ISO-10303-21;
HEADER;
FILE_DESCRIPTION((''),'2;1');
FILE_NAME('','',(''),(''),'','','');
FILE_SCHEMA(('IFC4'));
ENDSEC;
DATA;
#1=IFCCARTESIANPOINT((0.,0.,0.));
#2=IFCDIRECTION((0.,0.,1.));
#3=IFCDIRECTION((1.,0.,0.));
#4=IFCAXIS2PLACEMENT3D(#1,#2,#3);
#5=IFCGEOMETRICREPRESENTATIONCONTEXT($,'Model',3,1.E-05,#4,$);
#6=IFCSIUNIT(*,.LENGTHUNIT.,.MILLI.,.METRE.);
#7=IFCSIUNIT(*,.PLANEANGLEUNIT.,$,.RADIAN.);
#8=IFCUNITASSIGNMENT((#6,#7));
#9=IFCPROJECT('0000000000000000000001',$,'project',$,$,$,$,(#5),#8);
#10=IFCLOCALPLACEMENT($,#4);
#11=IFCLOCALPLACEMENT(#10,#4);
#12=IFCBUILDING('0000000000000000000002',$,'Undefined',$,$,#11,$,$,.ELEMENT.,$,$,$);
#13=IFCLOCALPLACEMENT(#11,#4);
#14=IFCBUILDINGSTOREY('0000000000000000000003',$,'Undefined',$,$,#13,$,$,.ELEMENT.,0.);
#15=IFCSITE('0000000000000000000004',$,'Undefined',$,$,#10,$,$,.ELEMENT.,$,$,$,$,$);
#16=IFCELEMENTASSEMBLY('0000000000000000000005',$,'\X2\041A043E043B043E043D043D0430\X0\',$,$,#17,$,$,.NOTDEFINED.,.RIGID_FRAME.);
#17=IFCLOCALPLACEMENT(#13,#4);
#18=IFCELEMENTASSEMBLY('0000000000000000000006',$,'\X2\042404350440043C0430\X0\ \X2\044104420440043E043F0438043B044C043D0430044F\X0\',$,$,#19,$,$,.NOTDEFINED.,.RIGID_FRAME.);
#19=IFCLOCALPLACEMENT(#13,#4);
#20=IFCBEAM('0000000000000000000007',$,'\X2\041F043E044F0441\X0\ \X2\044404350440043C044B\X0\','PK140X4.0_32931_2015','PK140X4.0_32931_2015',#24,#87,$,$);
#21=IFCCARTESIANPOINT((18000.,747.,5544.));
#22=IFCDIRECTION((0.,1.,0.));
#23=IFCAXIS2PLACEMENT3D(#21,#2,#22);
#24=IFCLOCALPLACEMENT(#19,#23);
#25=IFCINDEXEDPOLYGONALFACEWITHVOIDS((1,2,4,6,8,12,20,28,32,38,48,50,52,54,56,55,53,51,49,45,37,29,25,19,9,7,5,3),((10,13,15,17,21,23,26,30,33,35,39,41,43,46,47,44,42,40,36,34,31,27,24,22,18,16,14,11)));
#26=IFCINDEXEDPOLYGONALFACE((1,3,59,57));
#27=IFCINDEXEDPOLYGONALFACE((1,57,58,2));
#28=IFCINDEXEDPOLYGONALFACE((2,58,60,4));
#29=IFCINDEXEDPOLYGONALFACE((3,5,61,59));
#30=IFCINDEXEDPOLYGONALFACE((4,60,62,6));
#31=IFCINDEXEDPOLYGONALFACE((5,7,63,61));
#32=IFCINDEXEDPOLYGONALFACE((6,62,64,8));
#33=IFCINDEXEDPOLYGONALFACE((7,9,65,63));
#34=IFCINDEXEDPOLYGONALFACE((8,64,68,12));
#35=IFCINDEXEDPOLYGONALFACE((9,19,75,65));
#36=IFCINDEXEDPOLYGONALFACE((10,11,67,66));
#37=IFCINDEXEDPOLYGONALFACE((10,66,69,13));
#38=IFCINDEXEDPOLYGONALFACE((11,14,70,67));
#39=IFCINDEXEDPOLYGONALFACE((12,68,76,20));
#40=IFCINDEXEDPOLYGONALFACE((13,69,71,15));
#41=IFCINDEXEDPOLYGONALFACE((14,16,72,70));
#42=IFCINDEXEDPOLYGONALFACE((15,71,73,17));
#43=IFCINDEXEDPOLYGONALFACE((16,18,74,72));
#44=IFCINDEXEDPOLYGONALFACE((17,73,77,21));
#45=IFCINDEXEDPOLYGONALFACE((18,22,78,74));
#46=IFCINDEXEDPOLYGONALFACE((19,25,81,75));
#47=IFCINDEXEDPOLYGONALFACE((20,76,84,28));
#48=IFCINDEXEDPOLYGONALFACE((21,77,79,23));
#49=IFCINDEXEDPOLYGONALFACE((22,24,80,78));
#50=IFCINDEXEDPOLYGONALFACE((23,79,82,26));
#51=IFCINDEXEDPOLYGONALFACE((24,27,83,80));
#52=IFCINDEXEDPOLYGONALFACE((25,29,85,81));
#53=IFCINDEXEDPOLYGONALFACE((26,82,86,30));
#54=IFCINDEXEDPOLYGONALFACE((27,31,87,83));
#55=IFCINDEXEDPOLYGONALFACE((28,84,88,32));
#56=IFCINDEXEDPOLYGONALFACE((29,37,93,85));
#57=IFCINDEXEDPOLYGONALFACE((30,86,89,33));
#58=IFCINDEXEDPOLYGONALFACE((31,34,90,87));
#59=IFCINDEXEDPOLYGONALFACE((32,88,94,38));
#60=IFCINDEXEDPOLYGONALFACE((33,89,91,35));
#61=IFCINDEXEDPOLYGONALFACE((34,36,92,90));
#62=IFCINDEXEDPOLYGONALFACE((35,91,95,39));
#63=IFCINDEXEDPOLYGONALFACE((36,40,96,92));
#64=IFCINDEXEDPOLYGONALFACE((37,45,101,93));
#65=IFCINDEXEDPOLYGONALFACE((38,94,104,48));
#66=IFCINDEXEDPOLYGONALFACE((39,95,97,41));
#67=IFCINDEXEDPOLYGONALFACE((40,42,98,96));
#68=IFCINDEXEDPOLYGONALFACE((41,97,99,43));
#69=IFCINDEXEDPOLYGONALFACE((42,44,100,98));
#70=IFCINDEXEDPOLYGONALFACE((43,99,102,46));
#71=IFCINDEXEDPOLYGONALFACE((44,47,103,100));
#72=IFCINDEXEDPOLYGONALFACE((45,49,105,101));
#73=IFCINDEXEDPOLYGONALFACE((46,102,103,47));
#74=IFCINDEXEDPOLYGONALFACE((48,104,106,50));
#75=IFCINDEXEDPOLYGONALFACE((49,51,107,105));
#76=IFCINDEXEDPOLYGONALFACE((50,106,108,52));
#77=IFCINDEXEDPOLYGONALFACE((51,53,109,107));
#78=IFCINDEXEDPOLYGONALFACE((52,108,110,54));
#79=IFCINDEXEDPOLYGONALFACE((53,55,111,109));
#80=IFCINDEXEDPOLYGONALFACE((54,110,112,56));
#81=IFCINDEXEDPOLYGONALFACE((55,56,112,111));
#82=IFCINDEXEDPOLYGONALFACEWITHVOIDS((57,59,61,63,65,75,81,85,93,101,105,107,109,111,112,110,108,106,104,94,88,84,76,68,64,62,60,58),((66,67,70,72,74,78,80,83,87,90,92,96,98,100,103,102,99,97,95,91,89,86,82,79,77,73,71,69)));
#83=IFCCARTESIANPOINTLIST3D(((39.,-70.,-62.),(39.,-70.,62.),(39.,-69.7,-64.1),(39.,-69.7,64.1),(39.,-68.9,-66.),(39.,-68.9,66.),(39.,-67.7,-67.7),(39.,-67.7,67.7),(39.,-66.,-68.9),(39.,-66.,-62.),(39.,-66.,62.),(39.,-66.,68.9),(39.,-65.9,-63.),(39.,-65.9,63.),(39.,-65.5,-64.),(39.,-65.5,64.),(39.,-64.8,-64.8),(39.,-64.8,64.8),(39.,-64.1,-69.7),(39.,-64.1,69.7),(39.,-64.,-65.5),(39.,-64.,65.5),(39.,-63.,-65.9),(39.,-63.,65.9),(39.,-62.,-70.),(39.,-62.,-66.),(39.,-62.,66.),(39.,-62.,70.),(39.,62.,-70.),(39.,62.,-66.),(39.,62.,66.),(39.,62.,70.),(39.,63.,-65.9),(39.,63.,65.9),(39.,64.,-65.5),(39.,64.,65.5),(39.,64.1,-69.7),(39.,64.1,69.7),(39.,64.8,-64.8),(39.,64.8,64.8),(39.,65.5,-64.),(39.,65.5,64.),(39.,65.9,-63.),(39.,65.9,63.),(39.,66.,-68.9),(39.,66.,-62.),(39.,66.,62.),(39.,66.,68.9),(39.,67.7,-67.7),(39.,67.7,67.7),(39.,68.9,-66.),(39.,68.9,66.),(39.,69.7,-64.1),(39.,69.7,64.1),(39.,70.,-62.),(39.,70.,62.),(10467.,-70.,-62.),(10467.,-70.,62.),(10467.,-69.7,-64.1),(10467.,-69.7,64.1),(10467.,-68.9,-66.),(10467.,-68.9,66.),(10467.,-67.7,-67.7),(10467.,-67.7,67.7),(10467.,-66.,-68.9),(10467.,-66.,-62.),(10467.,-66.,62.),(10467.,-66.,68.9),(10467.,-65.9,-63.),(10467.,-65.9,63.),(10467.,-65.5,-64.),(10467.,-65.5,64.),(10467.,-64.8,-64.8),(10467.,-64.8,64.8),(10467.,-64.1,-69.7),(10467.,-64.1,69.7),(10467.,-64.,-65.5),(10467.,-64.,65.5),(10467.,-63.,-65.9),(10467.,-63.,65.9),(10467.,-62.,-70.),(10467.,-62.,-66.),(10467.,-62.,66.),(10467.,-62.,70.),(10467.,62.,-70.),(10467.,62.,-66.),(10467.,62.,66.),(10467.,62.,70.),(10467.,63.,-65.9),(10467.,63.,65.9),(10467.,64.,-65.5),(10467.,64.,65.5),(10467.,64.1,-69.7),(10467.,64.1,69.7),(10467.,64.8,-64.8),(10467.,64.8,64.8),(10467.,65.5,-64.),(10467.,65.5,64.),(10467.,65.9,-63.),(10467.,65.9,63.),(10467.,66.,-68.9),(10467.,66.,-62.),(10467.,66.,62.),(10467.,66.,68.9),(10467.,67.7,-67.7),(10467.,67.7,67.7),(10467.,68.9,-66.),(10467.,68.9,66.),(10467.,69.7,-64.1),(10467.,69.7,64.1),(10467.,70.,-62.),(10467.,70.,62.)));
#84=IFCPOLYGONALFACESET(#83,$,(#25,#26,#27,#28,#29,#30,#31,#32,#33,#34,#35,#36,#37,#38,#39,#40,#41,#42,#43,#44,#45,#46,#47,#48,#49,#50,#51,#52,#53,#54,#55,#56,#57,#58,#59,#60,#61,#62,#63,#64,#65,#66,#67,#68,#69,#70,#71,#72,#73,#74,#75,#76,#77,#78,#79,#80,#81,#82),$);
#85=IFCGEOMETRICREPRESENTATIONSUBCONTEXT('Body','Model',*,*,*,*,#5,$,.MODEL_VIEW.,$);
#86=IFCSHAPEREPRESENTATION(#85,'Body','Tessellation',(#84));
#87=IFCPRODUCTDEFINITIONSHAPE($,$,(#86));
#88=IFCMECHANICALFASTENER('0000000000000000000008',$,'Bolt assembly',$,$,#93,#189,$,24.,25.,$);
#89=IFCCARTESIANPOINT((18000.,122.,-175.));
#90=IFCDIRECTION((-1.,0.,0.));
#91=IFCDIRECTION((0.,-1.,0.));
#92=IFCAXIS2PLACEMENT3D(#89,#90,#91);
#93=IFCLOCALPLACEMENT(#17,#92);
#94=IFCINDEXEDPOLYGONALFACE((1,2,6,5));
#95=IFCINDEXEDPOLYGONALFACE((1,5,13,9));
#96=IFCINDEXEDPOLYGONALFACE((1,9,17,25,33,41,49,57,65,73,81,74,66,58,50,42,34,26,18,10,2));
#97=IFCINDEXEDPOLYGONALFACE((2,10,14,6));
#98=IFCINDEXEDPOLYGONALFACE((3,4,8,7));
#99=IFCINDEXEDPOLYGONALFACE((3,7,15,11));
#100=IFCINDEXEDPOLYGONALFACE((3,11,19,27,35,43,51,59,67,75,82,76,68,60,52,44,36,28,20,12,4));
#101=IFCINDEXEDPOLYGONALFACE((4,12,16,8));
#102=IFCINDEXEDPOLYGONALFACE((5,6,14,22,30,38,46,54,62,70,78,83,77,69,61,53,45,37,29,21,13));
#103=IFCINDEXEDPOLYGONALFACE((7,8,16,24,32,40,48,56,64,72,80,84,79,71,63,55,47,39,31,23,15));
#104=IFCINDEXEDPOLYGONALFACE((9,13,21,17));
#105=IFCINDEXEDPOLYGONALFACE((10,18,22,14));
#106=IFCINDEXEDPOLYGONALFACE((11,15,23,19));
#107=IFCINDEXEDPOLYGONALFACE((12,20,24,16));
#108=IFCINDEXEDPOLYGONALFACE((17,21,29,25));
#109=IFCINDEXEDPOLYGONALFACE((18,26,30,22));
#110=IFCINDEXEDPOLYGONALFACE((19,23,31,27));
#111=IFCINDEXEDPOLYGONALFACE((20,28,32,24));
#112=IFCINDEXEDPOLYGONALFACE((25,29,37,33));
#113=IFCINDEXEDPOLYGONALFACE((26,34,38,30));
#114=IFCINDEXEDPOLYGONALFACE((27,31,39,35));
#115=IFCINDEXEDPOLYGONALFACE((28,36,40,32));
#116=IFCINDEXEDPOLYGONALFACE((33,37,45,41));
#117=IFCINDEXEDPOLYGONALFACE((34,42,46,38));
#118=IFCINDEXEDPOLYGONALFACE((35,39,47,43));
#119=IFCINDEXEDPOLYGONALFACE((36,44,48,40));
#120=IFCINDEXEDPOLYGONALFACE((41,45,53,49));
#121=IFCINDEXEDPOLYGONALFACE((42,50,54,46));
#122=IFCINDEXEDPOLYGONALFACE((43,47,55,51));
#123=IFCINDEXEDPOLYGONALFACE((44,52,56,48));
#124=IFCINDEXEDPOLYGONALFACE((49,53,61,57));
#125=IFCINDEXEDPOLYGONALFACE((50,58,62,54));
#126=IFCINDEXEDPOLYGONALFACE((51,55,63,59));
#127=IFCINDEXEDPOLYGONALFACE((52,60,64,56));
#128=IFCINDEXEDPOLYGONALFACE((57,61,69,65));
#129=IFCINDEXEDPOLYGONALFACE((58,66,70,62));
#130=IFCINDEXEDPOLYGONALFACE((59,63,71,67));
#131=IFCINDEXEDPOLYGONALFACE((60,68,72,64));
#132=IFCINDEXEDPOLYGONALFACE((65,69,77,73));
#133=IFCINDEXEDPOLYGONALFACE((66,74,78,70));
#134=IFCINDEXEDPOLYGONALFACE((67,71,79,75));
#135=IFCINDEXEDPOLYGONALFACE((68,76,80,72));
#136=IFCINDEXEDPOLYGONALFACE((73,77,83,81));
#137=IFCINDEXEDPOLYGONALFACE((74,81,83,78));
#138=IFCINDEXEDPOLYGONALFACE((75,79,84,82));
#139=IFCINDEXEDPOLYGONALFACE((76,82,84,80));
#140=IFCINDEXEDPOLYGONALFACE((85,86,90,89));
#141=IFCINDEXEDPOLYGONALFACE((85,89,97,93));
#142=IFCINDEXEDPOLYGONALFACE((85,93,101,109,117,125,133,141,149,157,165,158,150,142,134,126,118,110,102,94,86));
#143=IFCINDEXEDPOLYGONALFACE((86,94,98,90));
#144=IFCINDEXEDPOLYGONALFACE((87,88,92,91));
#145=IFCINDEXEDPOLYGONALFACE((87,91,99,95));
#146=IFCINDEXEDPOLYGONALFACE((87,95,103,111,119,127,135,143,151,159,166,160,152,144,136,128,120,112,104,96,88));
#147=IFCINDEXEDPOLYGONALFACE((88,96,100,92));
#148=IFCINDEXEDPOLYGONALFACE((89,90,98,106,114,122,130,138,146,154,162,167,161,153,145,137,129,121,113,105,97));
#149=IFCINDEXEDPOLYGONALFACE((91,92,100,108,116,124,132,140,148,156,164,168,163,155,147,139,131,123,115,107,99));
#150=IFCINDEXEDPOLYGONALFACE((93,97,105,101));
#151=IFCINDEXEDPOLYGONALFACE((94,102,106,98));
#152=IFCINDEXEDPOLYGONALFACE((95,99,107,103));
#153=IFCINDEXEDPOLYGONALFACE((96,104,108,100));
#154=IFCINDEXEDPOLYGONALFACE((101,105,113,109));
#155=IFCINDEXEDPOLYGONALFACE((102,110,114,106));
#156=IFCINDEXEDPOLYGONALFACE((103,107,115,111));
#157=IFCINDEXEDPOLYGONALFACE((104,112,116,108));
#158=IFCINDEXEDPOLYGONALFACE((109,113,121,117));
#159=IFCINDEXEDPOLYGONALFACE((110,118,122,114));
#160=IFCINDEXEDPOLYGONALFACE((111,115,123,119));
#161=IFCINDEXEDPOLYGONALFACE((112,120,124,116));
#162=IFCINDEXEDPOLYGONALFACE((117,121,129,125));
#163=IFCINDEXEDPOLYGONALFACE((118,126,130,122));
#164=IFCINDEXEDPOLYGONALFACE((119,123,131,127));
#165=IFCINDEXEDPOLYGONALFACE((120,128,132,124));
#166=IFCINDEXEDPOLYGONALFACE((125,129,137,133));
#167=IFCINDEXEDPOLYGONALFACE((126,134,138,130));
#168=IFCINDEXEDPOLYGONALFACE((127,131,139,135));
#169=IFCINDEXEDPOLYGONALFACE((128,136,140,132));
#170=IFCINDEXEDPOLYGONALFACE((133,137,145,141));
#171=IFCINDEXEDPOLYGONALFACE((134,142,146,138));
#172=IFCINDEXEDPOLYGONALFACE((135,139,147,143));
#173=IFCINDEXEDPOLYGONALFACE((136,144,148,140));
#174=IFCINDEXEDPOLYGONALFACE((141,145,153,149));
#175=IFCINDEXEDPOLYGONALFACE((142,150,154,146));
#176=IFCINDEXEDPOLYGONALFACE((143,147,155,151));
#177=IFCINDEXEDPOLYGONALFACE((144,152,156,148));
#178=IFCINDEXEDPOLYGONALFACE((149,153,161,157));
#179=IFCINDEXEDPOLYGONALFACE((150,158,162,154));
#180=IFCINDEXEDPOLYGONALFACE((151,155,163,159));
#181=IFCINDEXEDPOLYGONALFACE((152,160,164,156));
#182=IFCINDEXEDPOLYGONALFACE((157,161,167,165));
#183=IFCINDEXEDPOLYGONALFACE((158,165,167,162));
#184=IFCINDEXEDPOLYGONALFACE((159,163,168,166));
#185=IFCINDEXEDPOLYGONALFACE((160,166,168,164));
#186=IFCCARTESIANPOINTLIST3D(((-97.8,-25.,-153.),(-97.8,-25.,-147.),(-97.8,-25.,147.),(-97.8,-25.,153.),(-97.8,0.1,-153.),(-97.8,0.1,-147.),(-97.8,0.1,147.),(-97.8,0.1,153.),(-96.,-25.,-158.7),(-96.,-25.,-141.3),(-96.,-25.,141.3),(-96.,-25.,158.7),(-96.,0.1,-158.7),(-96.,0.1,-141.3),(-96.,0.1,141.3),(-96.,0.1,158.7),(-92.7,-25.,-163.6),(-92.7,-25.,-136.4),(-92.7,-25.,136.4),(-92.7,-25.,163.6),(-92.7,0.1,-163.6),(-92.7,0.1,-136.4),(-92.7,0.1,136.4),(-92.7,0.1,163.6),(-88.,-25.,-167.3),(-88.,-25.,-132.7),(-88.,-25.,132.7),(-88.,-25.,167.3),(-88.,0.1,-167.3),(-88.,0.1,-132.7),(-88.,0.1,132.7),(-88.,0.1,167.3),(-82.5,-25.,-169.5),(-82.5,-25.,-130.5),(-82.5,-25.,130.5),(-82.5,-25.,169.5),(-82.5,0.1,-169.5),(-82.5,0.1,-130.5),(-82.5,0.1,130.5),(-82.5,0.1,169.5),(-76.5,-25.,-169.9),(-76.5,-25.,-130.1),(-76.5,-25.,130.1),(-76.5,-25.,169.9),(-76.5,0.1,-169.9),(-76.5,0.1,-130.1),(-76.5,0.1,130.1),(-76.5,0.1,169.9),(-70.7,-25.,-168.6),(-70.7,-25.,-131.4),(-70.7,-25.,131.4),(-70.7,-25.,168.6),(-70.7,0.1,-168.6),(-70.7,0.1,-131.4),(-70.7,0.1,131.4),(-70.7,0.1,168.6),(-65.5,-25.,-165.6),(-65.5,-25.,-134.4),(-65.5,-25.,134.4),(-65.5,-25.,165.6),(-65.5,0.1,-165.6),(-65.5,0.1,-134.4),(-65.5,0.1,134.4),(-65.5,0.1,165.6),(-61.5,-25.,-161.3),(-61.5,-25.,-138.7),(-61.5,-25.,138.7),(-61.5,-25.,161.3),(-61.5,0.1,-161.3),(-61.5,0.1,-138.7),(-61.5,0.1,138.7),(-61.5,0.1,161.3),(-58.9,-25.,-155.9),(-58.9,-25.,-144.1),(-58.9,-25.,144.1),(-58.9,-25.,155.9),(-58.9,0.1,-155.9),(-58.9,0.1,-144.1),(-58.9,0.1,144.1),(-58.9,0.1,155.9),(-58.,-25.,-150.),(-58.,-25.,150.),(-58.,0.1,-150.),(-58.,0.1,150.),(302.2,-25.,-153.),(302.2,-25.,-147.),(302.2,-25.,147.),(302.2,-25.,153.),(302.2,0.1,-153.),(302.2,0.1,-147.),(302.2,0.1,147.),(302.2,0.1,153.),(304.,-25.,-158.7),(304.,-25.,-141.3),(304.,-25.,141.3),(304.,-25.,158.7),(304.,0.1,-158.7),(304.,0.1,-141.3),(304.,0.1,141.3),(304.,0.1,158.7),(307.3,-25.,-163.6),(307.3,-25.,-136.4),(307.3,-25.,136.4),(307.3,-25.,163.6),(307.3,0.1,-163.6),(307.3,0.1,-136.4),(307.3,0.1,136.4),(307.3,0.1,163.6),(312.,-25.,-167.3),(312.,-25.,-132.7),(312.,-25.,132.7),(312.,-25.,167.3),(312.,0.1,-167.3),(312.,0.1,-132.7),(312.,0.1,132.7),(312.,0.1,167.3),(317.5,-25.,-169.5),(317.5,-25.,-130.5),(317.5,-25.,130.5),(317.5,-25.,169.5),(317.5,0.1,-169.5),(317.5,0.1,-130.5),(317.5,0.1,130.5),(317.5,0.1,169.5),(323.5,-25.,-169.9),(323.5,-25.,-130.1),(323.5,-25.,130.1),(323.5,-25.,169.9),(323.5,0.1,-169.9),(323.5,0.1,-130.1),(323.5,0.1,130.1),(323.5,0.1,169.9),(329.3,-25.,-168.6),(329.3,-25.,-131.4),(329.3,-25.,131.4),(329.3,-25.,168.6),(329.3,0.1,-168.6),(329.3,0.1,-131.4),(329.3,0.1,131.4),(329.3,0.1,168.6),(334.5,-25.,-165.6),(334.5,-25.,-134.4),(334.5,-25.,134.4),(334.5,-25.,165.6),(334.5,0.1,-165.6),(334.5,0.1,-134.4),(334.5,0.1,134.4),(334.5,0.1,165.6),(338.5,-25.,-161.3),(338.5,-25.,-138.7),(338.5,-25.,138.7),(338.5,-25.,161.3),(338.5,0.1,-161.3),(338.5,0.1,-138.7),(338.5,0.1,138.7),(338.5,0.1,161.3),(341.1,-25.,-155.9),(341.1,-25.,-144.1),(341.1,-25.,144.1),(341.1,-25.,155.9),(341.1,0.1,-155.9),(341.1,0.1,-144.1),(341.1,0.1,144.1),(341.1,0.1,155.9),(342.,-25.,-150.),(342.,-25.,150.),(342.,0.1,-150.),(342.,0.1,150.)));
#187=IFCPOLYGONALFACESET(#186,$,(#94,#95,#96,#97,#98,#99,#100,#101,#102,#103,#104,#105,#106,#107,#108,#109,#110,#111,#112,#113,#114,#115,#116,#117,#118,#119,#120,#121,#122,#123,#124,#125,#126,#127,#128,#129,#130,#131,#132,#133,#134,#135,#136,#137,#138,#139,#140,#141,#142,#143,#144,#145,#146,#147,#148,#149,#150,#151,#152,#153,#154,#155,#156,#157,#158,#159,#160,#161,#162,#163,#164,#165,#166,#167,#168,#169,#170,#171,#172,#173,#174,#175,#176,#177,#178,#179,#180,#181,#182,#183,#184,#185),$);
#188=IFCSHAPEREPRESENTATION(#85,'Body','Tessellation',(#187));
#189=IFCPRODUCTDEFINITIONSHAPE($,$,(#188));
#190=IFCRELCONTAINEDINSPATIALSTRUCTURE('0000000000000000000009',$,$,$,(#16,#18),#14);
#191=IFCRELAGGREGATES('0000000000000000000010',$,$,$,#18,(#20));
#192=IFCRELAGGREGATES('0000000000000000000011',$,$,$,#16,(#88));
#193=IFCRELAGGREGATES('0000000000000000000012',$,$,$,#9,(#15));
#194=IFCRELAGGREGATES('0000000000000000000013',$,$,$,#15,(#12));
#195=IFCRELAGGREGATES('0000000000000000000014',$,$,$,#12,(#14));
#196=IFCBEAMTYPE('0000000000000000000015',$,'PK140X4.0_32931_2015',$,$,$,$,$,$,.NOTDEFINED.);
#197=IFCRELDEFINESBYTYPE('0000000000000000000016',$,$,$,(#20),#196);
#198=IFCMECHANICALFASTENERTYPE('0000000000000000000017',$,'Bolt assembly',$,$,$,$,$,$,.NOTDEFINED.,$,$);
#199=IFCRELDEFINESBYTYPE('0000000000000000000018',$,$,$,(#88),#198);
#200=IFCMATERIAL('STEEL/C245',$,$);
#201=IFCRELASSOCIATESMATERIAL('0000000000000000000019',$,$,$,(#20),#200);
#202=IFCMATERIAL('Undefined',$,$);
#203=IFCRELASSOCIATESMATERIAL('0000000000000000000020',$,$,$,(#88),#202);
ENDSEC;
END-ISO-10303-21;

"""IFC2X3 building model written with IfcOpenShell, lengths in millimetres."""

from ifc_helpers import new_model, si_unit, frame, origin_with_axes, origin_2d_with_axis, place, context, subcontext, project, spatial, hollow_rectangle, circle, extrude, clip, halfspace, source, transform, mapped, material, type_object, element, aggregate, save


model = new_model("IFC2X3")

# Units and contexts
model_context = context("Model", 3, precision=1e-05, world=origin_with_axes())
body_context = subcontext(model_context, "Body", "Model", "MODEL_VIEW")
ifc_project = project(units=[si_unit("LENGTHUNIT", "METRE", prefix="MILLI"), si_unit("PLANEANGLEUNIT", "RADIAN")], contexts=[model_context])

# Site, building, storey
site_placement = place(None, origin_with_axes())
site = spatial("IfcSite", under=ifc_project, at=site_placement, Name="Undefined", CompositionType="ELEMENT")
building_placement = place(site_placement, origin_with_axes())
building = spatial("IfcBuilding", under=site, at=building_placement, Name="Undefined", CompositionType="ELEMENT")
storey_placement = place(building_placement, origin_with_axes())
storey = spatial("IfcBuildingStorey", under=building, at=storey_placement, Name="Undefined", CompositionType="ELEMENT", Elevation=0.0)

# Element assembly
ifc_material_1 = material(Name="STEEL/C245")
assembly_1_placement = place(storey_placement, origin_with_axes())
assembly_1 = element("IfcElementAssembly", 1, at=assembly_1_placement, inside=storey, Name="Колонна", AssemblyPlace="NOTDEFINED", PredefinedType="RIGID_FRAME")

# Element assembly, beam
assembly_2_placement = place(storey_placement, origin_with_axes())
assembly_2 = element("IfcElementAssembly", 2, at=assembly_2_placement, inside=storey, Name="Ферма стропильная", AssemblyPlace="NOTDEFINED", PredefinedType="RIGID_FRAME")
beam_type_1 = type_object("IfcBeamType", Name="PK140X4.0_32931_2015", PredefinedType="NOTDEFINED")
beam_1_placement = place(assembly_2_placement, frame((18000.0, 747.0, 5544.0), z_axis=(0.0, 0.0, 1.0), x_axis=(0.0, 1.0, 0.0)))
beam_1 = element("IfcBeam", 3, at=beam_1_placement, type_object=beam_type_1, material=ifc_material_1, Name="Пояс фермы", Description="PK140X4.0_32931_2015", ObjectType="PK140X4.0_32931_2015", context=body_context, shape_type="Clipping", body=[
    clip(clip(extrude(hollow_rectangle(XDim=140.0, YDim=140.0, WallThickness=4.0, InnerFilletRadius=4.0, OuterFilletRadius=8.0, at=origin_2d_with_axis()), frame((10467.0, 0.0, 0.0), z_axis=(-1.0, 0.0, 0.0), x_axis=(0.0, -1.0, 0.0)), (0.0, 0.0, 1.0), 10428.0), halfspace(frame((10467.0, 0.0, -70.0), z_axis=(-1.0, 0.0, 0.0), x_axis=(0.0, 1.0, 0.0)), True)), halfspace(frame((39.0, 0.0, -70.0), z_axis=(1.0, 0.0, 0.0), x_axis=(0.0, -1.0, 0.0)), True)),
])

aggregate(assembly_2, [beam_1])

# Mechanical fastener
ifc_material_2 = material(Name="Undefined")
mechanical_fastener_type = type_object("IfcMechanicalFastenerType", Name="Bolt assembly")
shared_shape_1 = source(origin_with_axes(), body_context, "Body", "SweptSolid", [
    extrude(circle(Radius=20.0, at=origin_2d_with_axis()), frame((0.0, -25.0, 0.0), z_axis=(0.0, 1.0, 0.0), x_axis=(1.0, 0.0, 0.0)), (0.0, 0.0, 1.0), 25.1),
])
mechanical_fastener_1_placement = place(assembly_1_placement, frame((18000.0, 122.0, -175.0), z_axis=(-1.0, 0.0, 0.0), x_axis=(0.0, -1.0, 0.0)))
mechanical_fastener_1 = element("IfcMechanicalFastener", 4, at=mechanical_fastener_1_placement, type_object=mechanical_fastener_type, material=ifc_material_2, Name="Bolt assembly", NominalDiameter=24.0, NominalLength=25.0, context=body_context, shape_type="MappedRepresentation", body=[
    mapped(shared_shape_1, transform((-78.0, 0.0, -150.0))),
    mapped(shared_shape_1, transform((-78.0, 0.0, 150.0))),
    mapped(shared_shape_1, transform((322.0, 0.0, -150.0))),
    mapped(shared_shape_1, transform((322.0, 0.0, 150.0))),
])
aggregate(assembly_1, [mechanical_fastener_1])

save(model, "model.ifc")
